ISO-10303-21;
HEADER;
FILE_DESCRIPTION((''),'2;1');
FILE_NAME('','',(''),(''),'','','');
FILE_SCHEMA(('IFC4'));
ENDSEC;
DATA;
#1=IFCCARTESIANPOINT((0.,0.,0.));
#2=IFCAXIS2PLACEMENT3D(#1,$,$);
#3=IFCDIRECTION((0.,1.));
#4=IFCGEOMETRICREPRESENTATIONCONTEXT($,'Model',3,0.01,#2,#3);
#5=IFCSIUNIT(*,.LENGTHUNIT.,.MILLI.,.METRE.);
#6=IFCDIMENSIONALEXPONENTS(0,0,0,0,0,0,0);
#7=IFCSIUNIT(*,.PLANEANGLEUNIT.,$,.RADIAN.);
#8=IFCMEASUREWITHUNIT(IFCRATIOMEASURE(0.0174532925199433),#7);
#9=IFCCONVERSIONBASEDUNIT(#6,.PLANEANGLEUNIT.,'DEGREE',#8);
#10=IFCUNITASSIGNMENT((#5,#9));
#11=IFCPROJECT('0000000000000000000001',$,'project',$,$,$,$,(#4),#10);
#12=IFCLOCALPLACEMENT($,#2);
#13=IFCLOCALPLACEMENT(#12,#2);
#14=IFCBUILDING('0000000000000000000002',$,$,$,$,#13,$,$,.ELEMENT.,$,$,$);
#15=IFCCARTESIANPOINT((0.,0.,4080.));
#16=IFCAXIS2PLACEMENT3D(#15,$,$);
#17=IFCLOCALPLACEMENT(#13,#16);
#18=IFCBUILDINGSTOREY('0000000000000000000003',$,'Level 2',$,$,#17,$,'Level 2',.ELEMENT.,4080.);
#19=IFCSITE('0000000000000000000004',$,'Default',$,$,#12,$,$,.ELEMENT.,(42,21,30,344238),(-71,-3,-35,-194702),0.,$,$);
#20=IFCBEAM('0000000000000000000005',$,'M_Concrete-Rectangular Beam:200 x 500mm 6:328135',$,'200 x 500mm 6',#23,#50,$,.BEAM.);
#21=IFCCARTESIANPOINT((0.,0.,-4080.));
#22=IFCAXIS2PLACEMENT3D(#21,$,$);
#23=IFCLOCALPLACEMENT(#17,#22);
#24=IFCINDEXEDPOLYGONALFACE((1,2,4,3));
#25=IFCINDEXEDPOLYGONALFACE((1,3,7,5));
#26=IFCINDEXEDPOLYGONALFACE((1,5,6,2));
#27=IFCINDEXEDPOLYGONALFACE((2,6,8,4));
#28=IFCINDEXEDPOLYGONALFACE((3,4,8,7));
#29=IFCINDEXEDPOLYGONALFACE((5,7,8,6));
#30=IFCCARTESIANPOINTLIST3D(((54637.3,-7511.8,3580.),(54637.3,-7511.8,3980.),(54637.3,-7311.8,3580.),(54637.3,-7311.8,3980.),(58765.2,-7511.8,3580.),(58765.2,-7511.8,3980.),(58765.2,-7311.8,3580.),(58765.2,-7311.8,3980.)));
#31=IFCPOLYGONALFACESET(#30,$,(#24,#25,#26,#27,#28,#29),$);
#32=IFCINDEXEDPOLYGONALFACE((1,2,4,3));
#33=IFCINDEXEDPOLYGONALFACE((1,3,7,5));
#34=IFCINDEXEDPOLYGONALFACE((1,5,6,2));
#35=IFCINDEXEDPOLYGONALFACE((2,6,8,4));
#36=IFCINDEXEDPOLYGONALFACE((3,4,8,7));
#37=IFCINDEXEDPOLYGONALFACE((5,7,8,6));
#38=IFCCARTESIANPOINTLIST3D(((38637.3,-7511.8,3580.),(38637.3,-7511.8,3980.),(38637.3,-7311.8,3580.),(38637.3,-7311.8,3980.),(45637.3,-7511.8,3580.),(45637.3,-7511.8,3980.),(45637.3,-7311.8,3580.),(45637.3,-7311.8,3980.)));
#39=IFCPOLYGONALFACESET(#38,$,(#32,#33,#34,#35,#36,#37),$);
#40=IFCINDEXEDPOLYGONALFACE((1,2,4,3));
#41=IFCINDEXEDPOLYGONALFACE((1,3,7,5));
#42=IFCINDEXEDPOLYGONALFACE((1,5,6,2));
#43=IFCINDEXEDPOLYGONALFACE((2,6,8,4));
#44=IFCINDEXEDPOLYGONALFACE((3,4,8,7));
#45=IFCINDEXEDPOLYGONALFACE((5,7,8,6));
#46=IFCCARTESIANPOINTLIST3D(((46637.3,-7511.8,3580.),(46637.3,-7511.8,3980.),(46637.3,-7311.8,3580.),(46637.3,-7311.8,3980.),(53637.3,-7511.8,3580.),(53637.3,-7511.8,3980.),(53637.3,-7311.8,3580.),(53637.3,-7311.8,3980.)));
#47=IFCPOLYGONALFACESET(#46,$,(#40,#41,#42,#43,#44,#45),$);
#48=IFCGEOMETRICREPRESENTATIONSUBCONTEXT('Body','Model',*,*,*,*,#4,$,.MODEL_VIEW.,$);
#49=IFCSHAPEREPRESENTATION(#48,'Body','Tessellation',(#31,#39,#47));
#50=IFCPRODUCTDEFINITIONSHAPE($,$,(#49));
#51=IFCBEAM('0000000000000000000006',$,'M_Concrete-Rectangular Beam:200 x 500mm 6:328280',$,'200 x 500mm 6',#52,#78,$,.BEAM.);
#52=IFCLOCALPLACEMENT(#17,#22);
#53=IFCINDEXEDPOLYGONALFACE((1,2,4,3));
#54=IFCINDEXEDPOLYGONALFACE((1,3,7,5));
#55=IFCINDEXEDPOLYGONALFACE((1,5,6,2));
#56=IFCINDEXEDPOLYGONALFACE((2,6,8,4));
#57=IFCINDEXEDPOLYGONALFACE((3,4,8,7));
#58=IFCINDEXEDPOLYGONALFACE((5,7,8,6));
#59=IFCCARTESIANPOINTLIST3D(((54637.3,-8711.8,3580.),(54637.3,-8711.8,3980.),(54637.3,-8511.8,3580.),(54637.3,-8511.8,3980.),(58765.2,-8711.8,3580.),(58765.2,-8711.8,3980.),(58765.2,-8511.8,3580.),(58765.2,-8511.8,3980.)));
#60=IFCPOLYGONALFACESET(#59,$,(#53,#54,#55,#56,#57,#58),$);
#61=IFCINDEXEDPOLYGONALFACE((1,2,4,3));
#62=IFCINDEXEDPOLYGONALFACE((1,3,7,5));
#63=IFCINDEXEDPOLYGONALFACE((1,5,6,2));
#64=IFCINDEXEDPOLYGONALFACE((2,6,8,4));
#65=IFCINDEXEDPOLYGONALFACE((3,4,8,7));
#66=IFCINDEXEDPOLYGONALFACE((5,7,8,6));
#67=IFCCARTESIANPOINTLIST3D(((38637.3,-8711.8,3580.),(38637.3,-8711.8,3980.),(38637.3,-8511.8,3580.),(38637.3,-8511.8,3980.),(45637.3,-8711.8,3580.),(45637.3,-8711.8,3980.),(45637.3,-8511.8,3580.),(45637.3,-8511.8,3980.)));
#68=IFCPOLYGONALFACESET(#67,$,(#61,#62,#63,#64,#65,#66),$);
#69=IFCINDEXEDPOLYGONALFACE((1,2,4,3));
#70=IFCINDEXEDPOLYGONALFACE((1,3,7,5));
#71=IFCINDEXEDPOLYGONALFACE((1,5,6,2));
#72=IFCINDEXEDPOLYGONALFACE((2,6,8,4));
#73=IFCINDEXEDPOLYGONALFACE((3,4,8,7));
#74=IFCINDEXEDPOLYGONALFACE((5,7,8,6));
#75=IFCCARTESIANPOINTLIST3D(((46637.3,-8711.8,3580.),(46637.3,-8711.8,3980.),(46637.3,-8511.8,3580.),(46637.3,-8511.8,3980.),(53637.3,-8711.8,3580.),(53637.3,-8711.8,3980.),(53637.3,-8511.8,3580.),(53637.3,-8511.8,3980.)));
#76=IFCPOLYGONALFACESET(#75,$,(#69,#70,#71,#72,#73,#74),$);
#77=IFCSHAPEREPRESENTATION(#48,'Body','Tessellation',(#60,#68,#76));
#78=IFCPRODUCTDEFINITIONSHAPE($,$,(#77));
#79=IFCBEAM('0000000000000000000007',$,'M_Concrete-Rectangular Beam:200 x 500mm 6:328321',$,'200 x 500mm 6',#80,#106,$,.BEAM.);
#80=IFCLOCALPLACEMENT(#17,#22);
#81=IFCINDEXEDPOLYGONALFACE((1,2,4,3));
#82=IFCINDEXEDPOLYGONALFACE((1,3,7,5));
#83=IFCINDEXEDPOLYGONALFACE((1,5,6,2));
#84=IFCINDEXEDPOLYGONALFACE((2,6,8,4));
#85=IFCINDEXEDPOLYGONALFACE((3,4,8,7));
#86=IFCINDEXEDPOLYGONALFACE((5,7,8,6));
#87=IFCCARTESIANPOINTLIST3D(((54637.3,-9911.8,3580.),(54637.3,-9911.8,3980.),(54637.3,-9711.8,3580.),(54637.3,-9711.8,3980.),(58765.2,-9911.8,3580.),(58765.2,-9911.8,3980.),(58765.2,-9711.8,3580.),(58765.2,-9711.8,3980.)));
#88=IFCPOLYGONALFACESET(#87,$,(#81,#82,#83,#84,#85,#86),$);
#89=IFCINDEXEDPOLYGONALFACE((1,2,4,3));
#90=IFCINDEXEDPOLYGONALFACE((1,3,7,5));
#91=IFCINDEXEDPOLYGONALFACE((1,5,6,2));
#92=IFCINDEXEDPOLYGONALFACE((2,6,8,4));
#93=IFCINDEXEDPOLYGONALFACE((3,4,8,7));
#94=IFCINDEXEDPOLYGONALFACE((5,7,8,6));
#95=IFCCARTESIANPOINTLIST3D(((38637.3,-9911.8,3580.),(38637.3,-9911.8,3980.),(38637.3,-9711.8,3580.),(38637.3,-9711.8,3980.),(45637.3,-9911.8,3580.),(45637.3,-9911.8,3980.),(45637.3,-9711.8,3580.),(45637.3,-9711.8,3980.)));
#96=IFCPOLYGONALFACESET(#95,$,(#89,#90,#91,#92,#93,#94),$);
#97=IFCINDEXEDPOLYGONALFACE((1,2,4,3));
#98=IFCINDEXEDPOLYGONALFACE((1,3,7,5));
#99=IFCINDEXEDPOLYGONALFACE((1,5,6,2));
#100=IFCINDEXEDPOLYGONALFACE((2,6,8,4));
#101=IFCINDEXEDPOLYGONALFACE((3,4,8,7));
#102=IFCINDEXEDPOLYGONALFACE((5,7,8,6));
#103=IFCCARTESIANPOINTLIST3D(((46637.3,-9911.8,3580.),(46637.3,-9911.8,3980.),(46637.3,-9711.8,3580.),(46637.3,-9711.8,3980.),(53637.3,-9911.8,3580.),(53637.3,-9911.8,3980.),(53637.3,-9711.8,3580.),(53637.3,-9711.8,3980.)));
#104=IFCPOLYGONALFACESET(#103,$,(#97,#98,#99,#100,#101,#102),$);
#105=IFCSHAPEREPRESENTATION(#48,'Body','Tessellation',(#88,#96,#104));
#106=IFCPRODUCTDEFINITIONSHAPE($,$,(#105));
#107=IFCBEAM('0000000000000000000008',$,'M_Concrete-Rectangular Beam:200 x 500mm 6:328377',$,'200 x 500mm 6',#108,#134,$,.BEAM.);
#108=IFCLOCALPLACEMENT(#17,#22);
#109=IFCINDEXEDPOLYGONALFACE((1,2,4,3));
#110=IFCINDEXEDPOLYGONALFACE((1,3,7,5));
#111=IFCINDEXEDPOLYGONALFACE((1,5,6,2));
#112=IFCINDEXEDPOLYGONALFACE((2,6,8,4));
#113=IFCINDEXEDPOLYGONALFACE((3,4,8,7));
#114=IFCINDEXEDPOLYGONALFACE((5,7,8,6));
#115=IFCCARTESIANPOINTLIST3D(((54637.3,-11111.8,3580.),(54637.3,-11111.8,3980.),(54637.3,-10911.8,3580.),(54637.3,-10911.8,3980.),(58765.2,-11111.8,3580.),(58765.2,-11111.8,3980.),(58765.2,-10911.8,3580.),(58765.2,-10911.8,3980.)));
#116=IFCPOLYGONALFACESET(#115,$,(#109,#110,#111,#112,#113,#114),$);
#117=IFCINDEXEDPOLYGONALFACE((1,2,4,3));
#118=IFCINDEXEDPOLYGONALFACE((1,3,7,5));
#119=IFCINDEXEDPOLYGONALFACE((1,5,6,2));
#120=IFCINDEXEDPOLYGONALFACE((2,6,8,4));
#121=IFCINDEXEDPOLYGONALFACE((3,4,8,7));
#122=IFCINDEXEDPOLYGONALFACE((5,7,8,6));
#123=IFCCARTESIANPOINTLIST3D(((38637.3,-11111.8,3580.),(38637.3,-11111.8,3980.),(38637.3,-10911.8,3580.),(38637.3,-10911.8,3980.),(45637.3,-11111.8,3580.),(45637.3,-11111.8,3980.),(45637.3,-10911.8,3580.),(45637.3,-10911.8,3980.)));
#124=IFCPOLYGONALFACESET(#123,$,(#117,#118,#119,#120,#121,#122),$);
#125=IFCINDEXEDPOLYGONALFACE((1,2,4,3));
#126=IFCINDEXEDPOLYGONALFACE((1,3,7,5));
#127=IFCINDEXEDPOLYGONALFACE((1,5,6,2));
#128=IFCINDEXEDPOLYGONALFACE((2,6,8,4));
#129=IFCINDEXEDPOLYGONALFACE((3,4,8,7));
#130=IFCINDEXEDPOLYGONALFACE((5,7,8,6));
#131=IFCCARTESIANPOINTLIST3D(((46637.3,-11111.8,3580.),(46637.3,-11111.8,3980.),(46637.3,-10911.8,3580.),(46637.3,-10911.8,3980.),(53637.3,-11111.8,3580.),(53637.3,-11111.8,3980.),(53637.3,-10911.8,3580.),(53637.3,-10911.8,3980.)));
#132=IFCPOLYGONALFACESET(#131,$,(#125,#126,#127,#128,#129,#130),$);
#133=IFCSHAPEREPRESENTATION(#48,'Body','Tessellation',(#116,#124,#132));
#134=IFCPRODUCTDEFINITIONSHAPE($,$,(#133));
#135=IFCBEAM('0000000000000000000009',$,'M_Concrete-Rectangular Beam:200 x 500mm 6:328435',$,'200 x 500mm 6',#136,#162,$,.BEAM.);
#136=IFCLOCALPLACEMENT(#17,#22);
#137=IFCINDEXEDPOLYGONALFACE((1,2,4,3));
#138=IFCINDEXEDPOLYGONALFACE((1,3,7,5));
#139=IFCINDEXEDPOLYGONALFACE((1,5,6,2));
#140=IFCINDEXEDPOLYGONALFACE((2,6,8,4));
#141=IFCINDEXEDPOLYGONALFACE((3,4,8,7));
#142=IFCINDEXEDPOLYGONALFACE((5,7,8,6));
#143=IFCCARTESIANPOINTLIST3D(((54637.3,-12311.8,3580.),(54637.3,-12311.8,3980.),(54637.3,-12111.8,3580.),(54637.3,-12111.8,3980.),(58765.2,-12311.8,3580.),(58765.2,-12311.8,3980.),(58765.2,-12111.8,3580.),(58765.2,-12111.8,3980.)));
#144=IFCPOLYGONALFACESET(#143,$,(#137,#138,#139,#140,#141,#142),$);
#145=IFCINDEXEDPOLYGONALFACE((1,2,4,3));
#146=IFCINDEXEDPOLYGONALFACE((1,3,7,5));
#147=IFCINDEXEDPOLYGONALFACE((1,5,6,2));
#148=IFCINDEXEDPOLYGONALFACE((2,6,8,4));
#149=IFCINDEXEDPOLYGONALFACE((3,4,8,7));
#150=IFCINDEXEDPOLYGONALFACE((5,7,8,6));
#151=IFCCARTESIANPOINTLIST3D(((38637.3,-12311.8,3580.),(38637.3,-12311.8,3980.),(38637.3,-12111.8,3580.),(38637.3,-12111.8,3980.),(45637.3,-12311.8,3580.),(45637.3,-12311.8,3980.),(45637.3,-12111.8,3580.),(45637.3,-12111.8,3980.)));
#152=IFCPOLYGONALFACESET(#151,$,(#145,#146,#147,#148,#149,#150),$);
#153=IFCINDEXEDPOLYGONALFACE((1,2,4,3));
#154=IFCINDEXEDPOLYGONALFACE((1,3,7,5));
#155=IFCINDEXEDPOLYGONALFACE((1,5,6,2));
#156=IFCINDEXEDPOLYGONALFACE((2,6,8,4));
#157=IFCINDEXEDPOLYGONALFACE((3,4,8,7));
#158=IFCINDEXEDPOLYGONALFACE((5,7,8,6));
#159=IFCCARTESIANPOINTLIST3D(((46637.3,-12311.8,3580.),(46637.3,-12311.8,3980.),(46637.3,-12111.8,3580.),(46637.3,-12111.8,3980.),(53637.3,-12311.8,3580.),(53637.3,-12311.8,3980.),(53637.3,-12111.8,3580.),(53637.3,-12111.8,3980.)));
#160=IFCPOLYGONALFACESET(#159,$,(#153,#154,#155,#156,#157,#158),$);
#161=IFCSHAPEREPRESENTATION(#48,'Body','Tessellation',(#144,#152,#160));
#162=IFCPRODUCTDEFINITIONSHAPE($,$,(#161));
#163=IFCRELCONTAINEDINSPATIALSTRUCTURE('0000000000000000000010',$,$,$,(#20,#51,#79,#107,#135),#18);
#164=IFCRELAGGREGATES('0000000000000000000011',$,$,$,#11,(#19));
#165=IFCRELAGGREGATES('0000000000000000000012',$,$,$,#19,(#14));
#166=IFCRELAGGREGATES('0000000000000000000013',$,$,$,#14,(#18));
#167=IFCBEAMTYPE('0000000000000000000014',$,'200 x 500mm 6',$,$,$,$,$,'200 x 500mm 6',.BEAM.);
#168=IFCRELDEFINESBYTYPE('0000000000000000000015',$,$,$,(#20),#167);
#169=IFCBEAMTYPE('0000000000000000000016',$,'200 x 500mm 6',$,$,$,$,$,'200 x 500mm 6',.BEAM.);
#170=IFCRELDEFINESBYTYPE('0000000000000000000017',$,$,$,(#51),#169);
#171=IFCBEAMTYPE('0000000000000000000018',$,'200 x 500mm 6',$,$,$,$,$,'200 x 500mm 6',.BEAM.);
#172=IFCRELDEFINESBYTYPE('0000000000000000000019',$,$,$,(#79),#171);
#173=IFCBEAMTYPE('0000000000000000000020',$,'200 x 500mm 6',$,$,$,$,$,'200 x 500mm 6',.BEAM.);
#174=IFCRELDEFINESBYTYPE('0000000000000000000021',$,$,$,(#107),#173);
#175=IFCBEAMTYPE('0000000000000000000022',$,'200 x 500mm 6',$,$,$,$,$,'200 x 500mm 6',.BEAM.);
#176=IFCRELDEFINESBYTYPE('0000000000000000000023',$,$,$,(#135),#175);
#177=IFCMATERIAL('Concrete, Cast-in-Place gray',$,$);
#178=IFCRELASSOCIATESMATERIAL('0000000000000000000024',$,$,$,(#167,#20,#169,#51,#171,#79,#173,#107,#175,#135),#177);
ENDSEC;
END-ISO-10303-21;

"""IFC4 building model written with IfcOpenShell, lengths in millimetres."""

from ifc_helpers import new_model, entity, si_unit, converted_unit, direction, frame, frame_2d, origin, place, context, subcontext, project, spatial, rectangle, extrude, source, transform, mapped, material, type_object, type_shapes, element, save


model = new_model("IFC4")

# Units and contexts
model_context = context("Model", 3, precision=0.01, world=origin(), true_north=direction((0.0, 1.0)))
body_context = subcontext(model_context, "Body", "Model", "MODEL_VIEW")
ifc_project = project(units=[si_unit("LENGTHUNIT", "METRE", prefix="MILLI"), converted_unit("PLANEANGLEUNIT", "DEGREE", entity("IfcRatioMeasure", 0.0174532925199433), si_unit("PLANEANGLEUNIT", "RADIAN"), dimensions=[0, 0, 0, 0, 0, 0, 0])], contexts=[model_context])

# Site, building, storey
site_placement = place(None, origin())
site = spatial("IfcSite", under=ifc_project, at=site_placement, Name="Default", CompositionType="ELEMENT", RefLatitude=(42, 21, 30, 344238), RefLongitude=(-71, -3, -35, -194702), RefElevation=0.0)
building_placement = place(site_placement, origin())
building = spatial("IfcBuilding", under=site, at=building_placement, CompositionType="ELEMENT")
storey_placement = place(building_placement, frame((0.0, 0.0, 4080.0)))
storey = spatial("IfcBuildingStorey", under=building, at=storey_placement, Name="Level 2", LongName="Level 2", CompositionType="ELEMENT", Elevation=4080.0)

# Beams
ifc_material = material(Name="Concrete, Cast-in-Place gray")
beam_type_1 = type_object("IfcBeamType", Name="200 x 500mm 6", ElementType="200 x 500mm 6", PredefinedType="BEAM", material=ifc_material)
shared_shape_1 = source(origin(), body_context, "Body", "SweptSolid", [
    extrude(rectangle(XDim=4127.9, YDim=200.0, at=frame_2d((214.5, 0.0), x_axis=(1.0, 0.0))), frame((56915.8, -7411.8, 3580.0), z_axis=(0.0, 0.0, 1.0), x_axis=(-1.0, 0.0, 0.0)), (0.0, 0.0, 1.0), 400.0),
    extrude(rectangle(XDim=7000.0, YDim=200.0, at=frame_2d((0.0, 0.0), x_axis=(1.0, 0.0))), frame((42137.3, -7411.8, 3580.0)), (0.0, 0.0, 1.0), 400.0),
    extrude(rectangle(XDim=7000.0, YDim=200.0, at=frame_2d((200.0, 0.0), x_axis=(1.0, 0.0))), frame((49937.3, -7411.8, 3580.0)), (0.0, 0.0, 1.0), 400.0),
])
type_shapes(beam_type_1, [shared_shape_1])
beam_1_placement = place(storey_placement, frame((0.0, 0.0, -4080.0)))
element("IfcBeam", 1, at=beam_1_placement, inside=storey, type_object=beam_type_1, material=ifc_material, Name="M_Concrete-Rectangular Beam:200 x 500mm 6:328135", ObjectType="200 x 500mm 6", PredefinedType="BEAM", context=body_context, shape_type="MappedRepresentation", body=[
    mapped(shared_shape_1, transform((0.0, 0.0, 0.0), scale=1.0)),
])
beam_type_2 = type_object("IfcBeamType", Name="200 x 500mm 6", ElementType="200 x 500mm 6", PredefinedType="BEAM", material=ifc_material)
shared_shape_2 = source(origin(), body_context, "Body", "SweptSolid", [
    extrude(rectangle(XDim=4127.9, YDim=200.0, at=frame_2d((214.5, 0.0), x_axis=(1.0, 0.0))), frame((56915.8, -8611.8, 3580.0), z_axis=(0.0, 0.0, 1.0), x_axis=(-1.0, 0.0, 0.0)), (0.0, 0.0, 1.0), 400.0),
    extrude(rectangle(XDim=7000.0, YDim=200.0, at=frame_2d((0.0, 0.0), x_axis=(1.0, 0.0))), frame((42137.3, -8611.8, 3580.0)), (0.0, 0.0, 1.0), 400.0),
    extrude(rectangle(XDim=7000.0, YDim=200.0, at=frame_2d((200.0, 0.0), x_axis=(1.0, 0.0))), frame((49937.3, -8611.8, 3580.0)), (0.0, 0.0, 1.0), 400.0),
])
type_shapes(beam_type_2, [shared_shape_2])
beam_2_placement = place(storey_placement, frame((0.0, 0.0, -4080.0)))
element("IfcBeam", 2, at=beam_2_placement, inside=storey, type_object=beam_type_2, material=ifc_material, Name="M_Concrete-Rectangular Beam:200 x 500mm 6:328280", ObjectType="200 x 500mm 6", PredefinedType="BEAM", context=body_context, shape_type="MappedRepresentation", body=[
    mapped(shared_shape_2, transform((0.0, 0.0, 0.0), scale=1.0)),
])
beam_type_3 = type_object("IfcBeamType", Name="200 x 500mm 6", ElementType="200 x 500mm 6", PredefinedType="BEAM", material=ifc_material)
shared_shape_3 = source(origin(), body_context, "Body", "SweptSolid", [
    extrude(rectangle(XDim=4127.9, YDim=200.0, at=frame_2d((214.5, 0.0), x_axis=(1.0, 0.0))), frame((56915.8, -9811.8, 3580.0), z_axis=(0.0, 0.0, 1.0), x_axis=(-1.0, 0.0, 0.0)), (0.0, 0.0, 1.0), 400.0),
    extrude(rectangle(XDim=7000.0, YDim=200.0, at=frame_2d((0.0, 0.0), x_axis=(1.0, 0.0))), frame((42137.3, -9811.8, 3580.0)), (0.0, 0.0, 1.0), 400.0),
    extrude(rectangle(XDim=7000.0, YDim=200.0, at=frame_2d((200.0, 0.0), x_axis=(1.0, 0.0))), frame((49937.3, -9811.8, 3580.0)), (0.0, 0.0, 1.0), 400.0),
])
type_shapes(beam_type_3, [shared_shape_3])
beam_3_placement = place(storey_placement, frame((0.0, 0.0, -4080.0)))
element("IfcBeam", 3, at=beam_3_placement, inside=storey, type_object=beam_type_3, material=ifc_material, Name="M_Concrete-Rectangular Beam:200 x 500mm 6:328321", ObjectType="200 x 500mm 6", PredefinedType="BEAM", context=body_context, shape_type="MappedRepresentation", body=[
    mapped(shared_shape_3, transform((0.0, 0.0, 0.0), scale=1.0)),
])
beam_type_4 = type_object("IfcBeamType", Name="200 x 500mm 6", ElementType="200 x 500mm 6", PredefinedType="BEAM", material=ifc_material)
shared_shape_4 = source(origin(), body_context, "Body", "SweptSolid", [
    extrude(rectangle(XDim=4127.9, YDim=200.0, at=frame_2d((214.5, 0.0), x_axis=(1.0, 0.0))), frame((56915.8, -11011.8, 3580.0), z_axis=(0.0, 0.0, 1.0), x_axis=(-1.0, 0.0, 0.0)), (0.0, 0.0, 1.0), 400.0),
    extrude(rectangle(XDim=7000.0, YDim=200.0, at=frame_2d((0.0, 0.0), x_axis=(1.0, 0.0))), frame((42137.3, -11011.8, 3580.0)), (0.0, 0.0, 1.0), 400.0),
    extrude(rectangle(XDim=7000.0, YDim=200.0, at=frame_2d((200.0, 0.0), x_axis=(1.0, 0.0))), frame((49937.3, -11011.8, 3580.0)), (0.0, 0.0, 1.0), 400.0),
])
type_shapes(beam_type_4, [shared_shape_4])
beam_4_placement = place(storey_placement, frame((0.0, 0.0, -4080.0)))
element("IfcBeam", 4, at=beam_4_placement, inside=storey, type_object=beam_type_4, material=ifc_material, Name="M_Concrete-Rectangular Beam:200 x 500mm 6:328377", ObjectType="200 x 500mm 6", PredefinedType="BEAM", context=body_context, shape_type="MappedRepresentation", body=[
    mapped(shared_shape_4, transform((0.0, 0.0, 0.0), scale=1.0)),
])
beam_type_5 = type_object("IfcBeamType", Name="200 x 500mm 6", ElementType="200 x 500mm 6", PredefinedType="BEAM", material=ifc_material)
shared_shape_5 = source(origin(), body_context, "Body", "SweptSolid", [
    extrude(rectangle(XDim=4127.9, YDim=200.0, at=frame_2d((214.5, 0.0), x_axis=(1.0, 0.0))), frame((56915.8, -12211.8, 3580.0), z_axis=(0.0, 0.0, 1.0), x_axis=(-1.0, 0.0, 0.0)), (0.0, 0.0, 1.0), 400.0),
    extrude(rectangle(XDim=7000.0, YDim=200.0, at=frame_2d((0.0, 0.0), x_axis=(1.0, 0.0))), frame((42137.3, -12211.8, 3580.0)), (0.0, 0.0, 1.0), 400.0),
    extrude(rectangle(XDim=7000.0, YDim=200.0, at=frame_2d((200.0, 0.0), x_axis=(1.0, 0.0))), frame((49937.3, -12211.8, 3580.0)), (0.0, 0.0, 1.0), 400.0),
])
type_shapes(beam_type_5, [shared_shape_5])
beam_5_placement = place(storey_placement, frame((0.0, 0.0, -4080.0)))
element("IfcBeam", 5, at=beam_5_placement, inside=storey, type_object=beam_type_5, material=ifc_material, Name="M_Concrete-Rectangular Beam:200 x 500mm 6:328435", ObjectType="200 x 500mm 6", PredefinedType="BEAM", context=body_context, shape_type="MappedRepresentation", body=[
    mapped(shared_shape_5, transform((0.0, 0.0, 0.0), scale=1.0)),
])

save(model, "model.ifc")
